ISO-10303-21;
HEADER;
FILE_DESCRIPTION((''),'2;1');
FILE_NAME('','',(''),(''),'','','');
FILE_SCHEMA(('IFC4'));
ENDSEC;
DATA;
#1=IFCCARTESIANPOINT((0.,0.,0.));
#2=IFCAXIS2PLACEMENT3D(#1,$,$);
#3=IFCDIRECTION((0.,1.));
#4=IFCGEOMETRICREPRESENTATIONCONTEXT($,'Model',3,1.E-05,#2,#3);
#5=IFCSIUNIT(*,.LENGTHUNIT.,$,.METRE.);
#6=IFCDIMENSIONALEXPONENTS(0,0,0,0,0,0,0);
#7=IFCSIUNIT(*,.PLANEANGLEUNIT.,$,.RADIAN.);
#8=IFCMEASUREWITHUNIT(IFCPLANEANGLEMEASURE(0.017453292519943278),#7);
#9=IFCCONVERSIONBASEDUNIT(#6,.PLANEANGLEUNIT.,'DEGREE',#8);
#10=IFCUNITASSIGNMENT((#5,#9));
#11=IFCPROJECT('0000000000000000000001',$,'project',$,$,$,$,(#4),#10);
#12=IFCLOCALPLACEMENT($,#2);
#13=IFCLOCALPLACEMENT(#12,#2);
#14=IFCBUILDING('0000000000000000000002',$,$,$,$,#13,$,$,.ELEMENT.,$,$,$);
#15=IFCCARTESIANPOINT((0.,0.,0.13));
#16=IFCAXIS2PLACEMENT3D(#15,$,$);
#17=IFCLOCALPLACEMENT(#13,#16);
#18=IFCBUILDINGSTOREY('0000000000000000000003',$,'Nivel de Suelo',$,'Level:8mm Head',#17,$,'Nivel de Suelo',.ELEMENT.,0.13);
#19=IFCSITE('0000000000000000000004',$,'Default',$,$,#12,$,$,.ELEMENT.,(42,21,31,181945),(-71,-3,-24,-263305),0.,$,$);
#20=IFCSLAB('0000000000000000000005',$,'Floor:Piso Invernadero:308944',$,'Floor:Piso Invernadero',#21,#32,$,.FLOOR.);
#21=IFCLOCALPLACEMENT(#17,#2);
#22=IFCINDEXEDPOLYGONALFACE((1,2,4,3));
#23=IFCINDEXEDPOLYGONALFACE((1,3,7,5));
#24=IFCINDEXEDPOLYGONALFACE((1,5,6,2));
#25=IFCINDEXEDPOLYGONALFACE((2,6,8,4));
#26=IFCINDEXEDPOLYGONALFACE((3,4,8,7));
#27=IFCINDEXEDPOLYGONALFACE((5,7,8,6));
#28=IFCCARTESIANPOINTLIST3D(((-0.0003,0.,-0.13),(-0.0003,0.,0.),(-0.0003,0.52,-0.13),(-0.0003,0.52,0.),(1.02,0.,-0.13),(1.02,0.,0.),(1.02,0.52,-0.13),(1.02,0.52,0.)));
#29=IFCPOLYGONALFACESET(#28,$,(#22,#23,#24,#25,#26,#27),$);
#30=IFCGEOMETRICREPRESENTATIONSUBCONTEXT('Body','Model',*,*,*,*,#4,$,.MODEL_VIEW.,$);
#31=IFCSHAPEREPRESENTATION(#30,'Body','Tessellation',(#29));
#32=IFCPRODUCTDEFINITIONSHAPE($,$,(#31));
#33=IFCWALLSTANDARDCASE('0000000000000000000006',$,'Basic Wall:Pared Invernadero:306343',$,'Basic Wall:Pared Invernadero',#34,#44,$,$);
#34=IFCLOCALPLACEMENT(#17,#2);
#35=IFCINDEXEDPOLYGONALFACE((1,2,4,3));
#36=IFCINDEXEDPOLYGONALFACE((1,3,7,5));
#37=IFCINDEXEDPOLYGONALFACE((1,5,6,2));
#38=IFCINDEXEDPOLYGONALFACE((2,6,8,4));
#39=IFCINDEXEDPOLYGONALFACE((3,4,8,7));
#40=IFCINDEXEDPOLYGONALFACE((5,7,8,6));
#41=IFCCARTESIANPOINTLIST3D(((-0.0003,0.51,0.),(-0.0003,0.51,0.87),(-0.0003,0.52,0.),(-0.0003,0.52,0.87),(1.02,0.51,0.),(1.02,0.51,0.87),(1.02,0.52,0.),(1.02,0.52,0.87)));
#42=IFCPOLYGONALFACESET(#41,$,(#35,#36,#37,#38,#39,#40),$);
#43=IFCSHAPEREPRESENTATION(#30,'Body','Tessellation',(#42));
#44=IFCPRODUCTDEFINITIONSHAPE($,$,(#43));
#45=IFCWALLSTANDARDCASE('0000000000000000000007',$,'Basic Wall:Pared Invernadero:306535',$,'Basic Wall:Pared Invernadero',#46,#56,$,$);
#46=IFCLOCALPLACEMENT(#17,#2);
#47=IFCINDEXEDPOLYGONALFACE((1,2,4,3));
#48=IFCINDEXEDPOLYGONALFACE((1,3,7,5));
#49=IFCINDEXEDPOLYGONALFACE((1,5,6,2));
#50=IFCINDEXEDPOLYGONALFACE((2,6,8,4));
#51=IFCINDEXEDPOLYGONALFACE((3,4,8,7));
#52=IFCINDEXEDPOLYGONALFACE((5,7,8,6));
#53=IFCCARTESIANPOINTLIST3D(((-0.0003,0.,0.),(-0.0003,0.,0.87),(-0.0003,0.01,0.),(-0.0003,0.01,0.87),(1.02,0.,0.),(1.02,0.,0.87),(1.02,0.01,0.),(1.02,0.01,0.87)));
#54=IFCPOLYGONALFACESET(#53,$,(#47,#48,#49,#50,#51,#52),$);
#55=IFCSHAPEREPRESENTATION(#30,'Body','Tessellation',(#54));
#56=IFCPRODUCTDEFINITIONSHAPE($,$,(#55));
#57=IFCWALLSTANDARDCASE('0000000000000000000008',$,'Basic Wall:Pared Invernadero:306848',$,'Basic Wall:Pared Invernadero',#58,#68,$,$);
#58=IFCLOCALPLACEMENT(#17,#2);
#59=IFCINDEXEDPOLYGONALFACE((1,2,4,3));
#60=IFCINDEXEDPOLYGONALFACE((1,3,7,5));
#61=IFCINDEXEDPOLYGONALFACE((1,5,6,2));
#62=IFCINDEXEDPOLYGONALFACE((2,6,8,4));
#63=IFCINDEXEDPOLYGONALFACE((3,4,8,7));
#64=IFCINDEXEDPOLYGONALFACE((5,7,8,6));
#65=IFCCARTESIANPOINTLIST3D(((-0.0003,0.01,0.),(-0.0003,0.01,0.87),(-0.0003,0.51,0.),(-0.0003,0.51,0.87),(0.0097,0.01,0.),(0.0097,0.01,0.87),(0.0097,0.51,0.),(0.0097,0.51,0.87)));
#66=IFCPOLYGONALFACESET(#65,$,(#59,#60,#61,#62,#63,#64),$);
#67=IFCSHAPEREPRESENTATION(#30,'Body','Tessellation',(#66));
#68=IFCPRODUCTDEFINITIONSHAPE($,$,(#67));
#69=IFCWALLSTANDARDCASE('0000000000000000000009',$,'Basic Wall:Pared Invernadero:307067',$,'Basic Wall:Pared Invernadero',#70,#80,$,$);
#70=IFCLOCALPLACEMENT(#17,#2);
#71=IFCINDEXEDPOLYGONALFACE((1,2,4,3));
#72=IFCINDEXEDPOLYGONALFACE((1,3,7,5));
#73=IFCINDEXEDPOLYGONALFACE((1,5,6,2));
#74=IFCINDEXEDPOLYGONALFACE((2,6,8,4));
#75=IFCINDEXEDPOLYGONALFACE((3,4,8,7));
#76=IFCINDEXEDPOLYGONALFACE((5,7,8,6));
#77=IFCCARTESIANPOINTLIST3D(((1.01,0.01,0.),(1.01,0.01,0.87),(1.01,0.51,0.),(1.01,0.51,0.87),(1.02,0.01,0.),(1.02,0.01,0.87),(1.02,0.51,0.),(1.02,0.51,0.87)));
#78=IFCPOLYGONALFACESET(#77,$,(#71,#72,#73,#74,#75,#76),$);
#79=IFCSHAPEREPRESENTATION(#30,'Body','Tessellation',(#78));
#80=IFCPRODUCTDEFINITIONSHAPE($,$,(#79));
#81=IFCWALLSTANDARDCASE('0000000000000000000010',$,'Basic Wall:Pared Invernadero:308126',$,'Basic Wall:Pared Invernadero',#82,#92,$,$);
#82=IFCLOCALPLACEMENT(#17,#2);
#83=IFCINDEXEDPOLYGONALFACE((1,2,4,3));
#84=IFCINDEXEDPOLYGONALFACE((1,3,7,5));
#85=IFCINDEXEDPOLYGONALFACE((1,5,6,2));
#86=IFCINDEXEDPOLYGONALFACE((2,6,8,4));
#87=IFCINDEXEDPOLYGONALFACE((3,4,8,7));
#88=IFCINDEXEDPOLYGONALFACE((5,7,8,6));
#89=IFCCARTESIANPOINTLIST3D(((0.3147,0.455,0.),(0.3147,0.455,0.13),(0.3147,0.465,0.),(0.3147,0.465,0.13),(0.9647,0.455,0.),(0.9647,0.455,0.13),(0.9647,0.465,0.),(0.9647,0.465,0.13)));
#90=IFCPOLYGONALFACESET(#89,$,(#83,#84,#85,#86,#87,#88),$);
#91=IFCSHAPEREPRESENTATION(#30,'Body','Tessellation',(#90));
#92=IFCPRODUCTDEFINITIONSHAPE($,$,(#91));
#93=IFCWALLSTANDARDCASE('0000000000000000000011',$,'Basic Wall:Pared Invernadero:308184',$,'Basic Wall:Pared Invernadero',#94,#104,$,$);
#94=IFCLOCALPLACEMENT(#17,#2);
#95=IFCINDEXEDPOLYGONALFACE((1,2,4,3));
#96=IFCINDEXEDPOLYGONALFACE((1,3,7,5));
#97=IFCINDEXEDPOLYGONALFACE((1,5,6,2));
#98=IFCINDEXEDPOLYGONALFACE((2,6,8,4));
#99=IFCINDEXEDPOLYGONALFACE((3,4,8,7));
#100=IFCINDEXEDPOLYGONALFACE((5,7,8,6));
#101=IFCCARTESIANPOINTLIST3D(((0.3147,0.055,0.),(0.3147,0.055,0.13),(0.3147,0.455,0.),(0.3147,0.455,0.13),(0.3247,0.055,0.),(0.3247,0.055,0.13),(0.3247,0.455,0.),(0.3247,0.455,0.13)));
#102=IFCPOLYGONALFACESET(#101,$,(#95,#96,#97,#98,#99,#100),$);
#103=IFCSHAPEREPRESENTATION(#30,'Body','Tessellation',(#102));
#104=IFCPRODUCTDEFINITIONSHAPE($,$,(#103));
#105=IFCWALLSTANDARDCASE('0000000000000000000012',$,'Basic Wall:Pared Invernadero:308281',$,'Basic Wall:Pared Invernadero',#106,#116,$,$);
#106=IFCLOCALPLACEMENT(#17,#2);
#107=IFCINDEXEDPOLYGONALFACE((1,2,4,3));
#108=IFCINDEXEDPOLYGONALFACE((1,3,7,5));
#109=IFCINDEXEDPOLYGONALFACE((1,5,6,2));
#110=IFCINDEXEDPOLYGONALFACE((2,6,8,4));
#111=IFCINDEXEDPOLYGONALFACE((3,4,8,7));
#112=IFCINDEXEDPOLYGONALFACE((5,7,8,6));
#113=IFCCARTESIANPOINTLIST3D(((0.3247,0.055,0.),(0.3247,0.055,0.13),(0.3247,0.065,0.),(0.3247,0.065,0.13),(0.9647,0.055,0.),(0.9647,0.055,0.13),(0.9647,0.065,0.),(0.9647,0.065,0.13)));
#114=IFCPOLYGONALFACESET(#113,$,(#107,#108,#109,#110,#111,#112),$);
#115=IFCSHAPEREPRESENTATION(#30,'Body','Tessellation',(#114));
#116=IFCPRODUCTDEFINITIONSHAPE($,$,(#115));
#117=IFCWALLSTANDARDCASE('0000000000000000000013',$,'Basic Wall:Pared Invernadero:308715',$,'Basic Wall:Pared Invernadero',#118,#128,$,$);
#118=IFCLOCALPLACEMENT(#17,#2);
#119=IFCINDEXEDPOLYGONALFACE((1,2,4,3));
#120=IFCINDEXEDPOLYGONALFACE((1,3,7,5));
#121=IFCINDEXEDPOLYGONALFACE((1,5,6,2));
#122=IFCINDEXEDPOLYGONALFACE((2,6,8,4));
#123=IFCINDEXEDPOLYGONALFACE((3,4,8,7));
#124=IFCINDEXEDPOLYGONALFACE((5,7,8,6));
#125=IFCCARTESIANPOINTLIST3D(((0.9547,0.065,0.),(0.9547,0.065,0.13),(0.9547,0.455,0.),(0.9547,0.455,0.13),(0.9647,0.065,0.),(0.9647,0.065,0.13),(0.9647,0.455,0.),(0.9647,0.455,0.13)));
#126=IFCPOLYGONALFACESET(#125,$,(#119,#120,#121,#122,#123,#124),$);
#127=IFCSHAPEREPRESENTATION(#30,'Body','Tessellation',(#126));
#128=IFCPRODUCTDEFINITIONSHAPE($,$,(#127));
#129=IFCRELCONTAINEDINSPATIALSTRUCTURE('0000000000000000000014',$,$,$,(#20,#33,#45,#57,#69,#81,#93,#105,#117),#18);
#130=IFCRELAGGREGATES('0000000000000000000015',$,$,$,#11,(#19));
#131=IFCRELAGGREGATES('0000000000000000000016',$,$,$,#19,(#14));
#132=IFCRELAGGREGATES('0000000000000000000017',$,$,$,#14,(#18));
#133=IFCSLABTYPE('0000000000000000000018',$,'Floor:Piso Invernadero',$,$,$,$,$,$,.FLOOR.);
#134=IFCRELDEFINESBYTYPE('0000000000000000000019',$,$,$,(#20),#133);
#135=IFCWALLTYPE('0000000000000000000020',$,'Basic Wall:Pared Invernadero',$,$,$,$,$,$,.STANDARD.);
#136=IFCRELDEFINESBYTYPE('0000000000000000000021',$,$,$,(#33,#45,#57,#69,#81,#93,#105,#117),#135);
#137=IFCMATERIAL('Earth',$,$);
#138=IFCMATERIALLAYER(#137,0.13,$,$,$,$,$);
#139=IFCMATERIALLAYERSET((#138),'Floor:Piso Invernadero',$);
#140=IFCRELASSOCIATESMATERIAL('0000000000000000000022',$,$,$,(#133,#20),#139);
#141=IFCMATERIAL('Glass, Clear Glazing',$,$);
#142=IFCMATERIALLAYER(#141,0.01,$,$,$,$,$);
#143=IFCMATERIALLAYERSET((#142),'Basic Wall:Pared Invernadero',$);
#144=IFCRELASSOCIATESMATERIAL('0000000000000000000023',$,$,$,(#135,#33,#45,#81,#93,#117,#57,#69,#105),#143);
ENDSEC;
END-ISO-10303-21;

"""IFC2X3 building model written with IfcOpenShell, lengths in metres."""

from ifc_helpers import new_model, entity, si_unit, converted_unit, direction, frame, frame_2d, origin, origin_2d_with_axis, place, context, subcontext, project, spatial, rectangle, extrude, material, layer, layer_set, layer_usage, type_object, element, save


model = new_model("IFC2X3")

# Units and contexts
model_context = context("Model", 3, precision=1e-05, world=origin(), true_north=direction((0.0, 1.0)))
body_context = subcontext(model_context, "Body", "Model", "MODEL_VIEW")
ifc_project = project(units=[si_unit("LENGTHUNIT", "METRE"), converted_unit("PLANEANGLEUNIT", "DEGREE", entity("IfcPlaneAngleMeasure", 0.017453292519943278), si_unit("PLANEANGLEUNIT", "RADIAN"), dimensions=[0, 0, 0, 0, 0, 0, 0])], contexts=[model_context])

# Site, building, storey
site_placement = place(None, origin())
site = spatial("IfcSite", under=ifc_project, at=site_placement, Name="Default", CompositionType="ELEMENT", RefLatitude=(42, 21, 31, 181945), RefLongitude=(-71, -3, -24, -263305), RefElevation=0.0)
building_placement = place(site_placement, origin())
building = spatial("IfcBuilding", under=site, at=building_placement, CompositionType="ELEMENT")
storey_placement = place(building_placement, frame((0.0, 0.0, 0.13)))
storey = spatial("IfcBuildingStorey", under=building, at=storey_placement, Name="Nivel de Suelo", ObjectType="Level:8mm Head", LongName="Nivel de Suelo", CompositionType="ELEMENT", Elevation=0.13)

# Slab
ifc_material_1 = material(Name="Earth")
ifc_layer_1 = layer(ifc_material_1, 0.13)
ifc_layer_set_1 = layer_set([ifc_layer_1], Name="Floor:Piso Invernadero")
ifc_layer_usage_1 = layer_usage(ifc_layer_set_1, "AXIS3", "POSITIVE", 0.0)
slab_type = type_object("IfcSlabType", Name="Floor:Piso Invernadero", PredefinedType="FLOOR", material=ifc_layer_set_1)
slab_placement = place(storey_placement, origin())
element("IfcSlab", 1, at=slab_placement, inside=storey, type_object=slab_type, material=ifc_layer_usage_1, Name="Floor:Piso Invernadero:308944", ObjectType="Floor:Piso Invernadero", PredefinedType="FLOOR", context=body_context, shape_type="SweptSolid", body=[
    extrude(rectangle(XDim=0.52, YDim=1.0204, at=origin_2d_with_axis()), frame((0.5099, 0.26, 0.0), z_axis=(0.0, 0.0, -1.0), x_axis=(0.0, 1.0, 0.0)), (0.0, 0.0, 1.0), 0.13),
])

# Walls
ifc_material_2 = material(Name="Glass, Clear Glazing")
ifc_layer_2 = layer(ifc_material_2, 0.01)
ifc_layer_set_2 = layer_set([ifc_layer_2], Name="Basic Wall:Pared Invernadero")
ifc_layer_usage_2 = layer_usage(ifc_layer_set_2, "AXIS2", "NEGATIVE", 0.005)
wall_type = type_object("IfcWallType", Name="Basic Wall:Pared Invernadero", PredefinedType="STANDARD", material=ifc_layer_set_2)
wall_1_placement = place(storey_placement, frame((-0.0003, 0.515, 0.0)))
element("IfcWallStandardCase", 2, at=wall_1_placement, inside=storey, type_object=wall_type, material=ifc_layer_usage_2, Name="Basic Wall:Pared Invernadero:306343", ObjectType="Basic Wall:Pared Invernadero", context=body_context, shape_type="SweptSolid", body=[
    extrude(rectangle(XDim=1.0204, YDim=0.01, at=frame_2d((0.5102, 0.0), x_axis=(-1.0, 0.0))), origin(), (0.0, 0.0, 1.0), 0.87),
])
wall_2_placement = place(storey_placement, frame((-0.0003, 0.005, 0.0)))
element("IfcWallStandardCase", 3, at=wall_2_placement, inside=storey, type_object=wall_type, material=ifc_layer_usage_2, Name="Basic Wall:Pared Invernadero:306535", ObjectType="Basic Wall:Pared Invernadero", context=body_context, shape_type="SweptSolid", body=[
    extrude(rectangle(XDim=1.0204, YDim=0.01, at=frame_2d((0.5102, 0.0), x_axis=(-1.0, 0.0))), origin(), (0.0, 0.0, 1.0), 0.87),
])
ifc_layer_usage_3 = layer_usage(ifc_layer_set_2, "AXIS2", "POSITIVE", -0.005)
wall_3_placement = place(storey_placement, frame((0.0047, 0.51, 0.0), z_axis=(0.0, 0.0, 1.0), x_axis=(0.0, -1.0, 0.0)))
element("IfcWallStandardCase", 4, at=wall_3_placement, inside=storey, type_object=wall_type, material=ifc_layer_usage_3, Name="Basic Wall:Pared Invernadero:306848", ObjectType="Basic Wall:Pared Invernadero", context=body_context, shape_type="SweptSolid", body=[
    extrude(rectangle(XDim=0.5, YDim=0.01, at=frame_2d((0.25, 0.0), x_axis=(-1.0, 0.0))), origin(), (0.0, 0.0, 1.0), 0.87),
])
wall_4_placement = place(storey_placement, frame((1.015, 0.51, 0.0), z_axis=(0.0, 0.0, 1.0), x_axis=(0.0, -1.0, 0.0)))
element("IfcWallStandardCase", 5, at=wall_4_placement, inside=storey, type_object=wall_type, material=ifc_layer_usage_3, Name="Basic Wall:Pared Invernadero:307067", ObjectType="Basic Wall:Pared Invernadero", context=body_context, shape_type="SweptSolid", body=[
    extrude(rectangle(XDim=0.5, YDim=0.01, at=frame_2d((0.25, 0.0), x_axis=(-1.0, 0.0))), origin(), (0.0, 0.0, 1.0), 0.87),
])
wall_5_placement = place(storey_placement, frame((0.9647, 0.46, 0.0), z_axis=(0.0, 0.0, 1.0), x_axis=(-1.0, 0.0, 0.0)))
element("IfcWallStandardCase", 6, at=wall_5_placement, inside=storey, type_object=wall_type, material=ifc_layer_usage_2, Name="Basic Wall:Pared Invernadero:308126", ObjectType="Basic Wall:Pared Invernadero", context=body_context, shape_type="SweptSolid", body=[
    extrude(rectangle(XDim=0.65, YDim=0.01, at=frame_2d((0.325, 0.0), x_axis=(-1.0, 0.0))), origin(), (0.0, 0.0, 1.0), 0.13),
])
wall_6_placement = place(storey_placement, frame((0.3197, 0.455, 0.0), z_axis=(0.0, 0.0, 1.0), x_axis=(0.0, -1.0, 0.0)))
element("IfcWallStandardCase", 7, at=wall_6_placement, inside=storey, type_object=wall_type, material=ifc_layer_usage_2, Name="Basic Wall:Pared Invernadero:308184", ObjectType="Basic Wall:Pared Invernadero", context=body_context, shape_type="SweptSolid", body=[
    extrude(rectangle(XDim=0.4, YDim=0.01, at=frame_2d((0.2, 0.0), x_axis=(-1.0, 0.0))), origin(), (0.0, 0.0, 1.0), 0.13),
])
wall_7_placement = place(storey_placement, frame((0.3247, 0.06, 0.0)))
element("IfcWallStandardCase", 8, at=wall_7_placement, inside=storey, type_object=wall_type, material=ifc_layer_usage_3, Name="Basic Wall:Pared Invernadero:308281", ObjectType="Basic Wall:Pared Invernadero", context=body_context, shape_type="SweptSolid", body=[
    extrude(rectangle(XDim=0.64, YDim=0.01, at=frame_2d((0.32, 0.0), x_axis=(-1.0, 0.0))), origin(), (0.0, 0.0, 1.0), 0.13),
])
wall_8_placement = place(storey_placement, frame((0.9597, 0.455, 0.0), z_axis=(0.0, 0.0, 1.0), x_axis=(0.0, -1.0, 0.0)))
element("IfcWallStandardCase", 9, at=wall_8_placement, inside=storey, type_object=wall_type, material=ifc_layer_usage_2, Name="Basic Wall:Pared Invernadero:308715", ObjectType="Basic Wall:Pared Invernadero", context=body_context, shape_type="SweptSolid", body=[
    extrude(rectangle(XDim=0.39, YDim=0.01, at=frame_2d((0.195, 0.0), x_axis=(-1.0, 0.0))), origin(), (0.0, 0.0, 1.0), 0.13),
])

save(model, "model.ifc")
